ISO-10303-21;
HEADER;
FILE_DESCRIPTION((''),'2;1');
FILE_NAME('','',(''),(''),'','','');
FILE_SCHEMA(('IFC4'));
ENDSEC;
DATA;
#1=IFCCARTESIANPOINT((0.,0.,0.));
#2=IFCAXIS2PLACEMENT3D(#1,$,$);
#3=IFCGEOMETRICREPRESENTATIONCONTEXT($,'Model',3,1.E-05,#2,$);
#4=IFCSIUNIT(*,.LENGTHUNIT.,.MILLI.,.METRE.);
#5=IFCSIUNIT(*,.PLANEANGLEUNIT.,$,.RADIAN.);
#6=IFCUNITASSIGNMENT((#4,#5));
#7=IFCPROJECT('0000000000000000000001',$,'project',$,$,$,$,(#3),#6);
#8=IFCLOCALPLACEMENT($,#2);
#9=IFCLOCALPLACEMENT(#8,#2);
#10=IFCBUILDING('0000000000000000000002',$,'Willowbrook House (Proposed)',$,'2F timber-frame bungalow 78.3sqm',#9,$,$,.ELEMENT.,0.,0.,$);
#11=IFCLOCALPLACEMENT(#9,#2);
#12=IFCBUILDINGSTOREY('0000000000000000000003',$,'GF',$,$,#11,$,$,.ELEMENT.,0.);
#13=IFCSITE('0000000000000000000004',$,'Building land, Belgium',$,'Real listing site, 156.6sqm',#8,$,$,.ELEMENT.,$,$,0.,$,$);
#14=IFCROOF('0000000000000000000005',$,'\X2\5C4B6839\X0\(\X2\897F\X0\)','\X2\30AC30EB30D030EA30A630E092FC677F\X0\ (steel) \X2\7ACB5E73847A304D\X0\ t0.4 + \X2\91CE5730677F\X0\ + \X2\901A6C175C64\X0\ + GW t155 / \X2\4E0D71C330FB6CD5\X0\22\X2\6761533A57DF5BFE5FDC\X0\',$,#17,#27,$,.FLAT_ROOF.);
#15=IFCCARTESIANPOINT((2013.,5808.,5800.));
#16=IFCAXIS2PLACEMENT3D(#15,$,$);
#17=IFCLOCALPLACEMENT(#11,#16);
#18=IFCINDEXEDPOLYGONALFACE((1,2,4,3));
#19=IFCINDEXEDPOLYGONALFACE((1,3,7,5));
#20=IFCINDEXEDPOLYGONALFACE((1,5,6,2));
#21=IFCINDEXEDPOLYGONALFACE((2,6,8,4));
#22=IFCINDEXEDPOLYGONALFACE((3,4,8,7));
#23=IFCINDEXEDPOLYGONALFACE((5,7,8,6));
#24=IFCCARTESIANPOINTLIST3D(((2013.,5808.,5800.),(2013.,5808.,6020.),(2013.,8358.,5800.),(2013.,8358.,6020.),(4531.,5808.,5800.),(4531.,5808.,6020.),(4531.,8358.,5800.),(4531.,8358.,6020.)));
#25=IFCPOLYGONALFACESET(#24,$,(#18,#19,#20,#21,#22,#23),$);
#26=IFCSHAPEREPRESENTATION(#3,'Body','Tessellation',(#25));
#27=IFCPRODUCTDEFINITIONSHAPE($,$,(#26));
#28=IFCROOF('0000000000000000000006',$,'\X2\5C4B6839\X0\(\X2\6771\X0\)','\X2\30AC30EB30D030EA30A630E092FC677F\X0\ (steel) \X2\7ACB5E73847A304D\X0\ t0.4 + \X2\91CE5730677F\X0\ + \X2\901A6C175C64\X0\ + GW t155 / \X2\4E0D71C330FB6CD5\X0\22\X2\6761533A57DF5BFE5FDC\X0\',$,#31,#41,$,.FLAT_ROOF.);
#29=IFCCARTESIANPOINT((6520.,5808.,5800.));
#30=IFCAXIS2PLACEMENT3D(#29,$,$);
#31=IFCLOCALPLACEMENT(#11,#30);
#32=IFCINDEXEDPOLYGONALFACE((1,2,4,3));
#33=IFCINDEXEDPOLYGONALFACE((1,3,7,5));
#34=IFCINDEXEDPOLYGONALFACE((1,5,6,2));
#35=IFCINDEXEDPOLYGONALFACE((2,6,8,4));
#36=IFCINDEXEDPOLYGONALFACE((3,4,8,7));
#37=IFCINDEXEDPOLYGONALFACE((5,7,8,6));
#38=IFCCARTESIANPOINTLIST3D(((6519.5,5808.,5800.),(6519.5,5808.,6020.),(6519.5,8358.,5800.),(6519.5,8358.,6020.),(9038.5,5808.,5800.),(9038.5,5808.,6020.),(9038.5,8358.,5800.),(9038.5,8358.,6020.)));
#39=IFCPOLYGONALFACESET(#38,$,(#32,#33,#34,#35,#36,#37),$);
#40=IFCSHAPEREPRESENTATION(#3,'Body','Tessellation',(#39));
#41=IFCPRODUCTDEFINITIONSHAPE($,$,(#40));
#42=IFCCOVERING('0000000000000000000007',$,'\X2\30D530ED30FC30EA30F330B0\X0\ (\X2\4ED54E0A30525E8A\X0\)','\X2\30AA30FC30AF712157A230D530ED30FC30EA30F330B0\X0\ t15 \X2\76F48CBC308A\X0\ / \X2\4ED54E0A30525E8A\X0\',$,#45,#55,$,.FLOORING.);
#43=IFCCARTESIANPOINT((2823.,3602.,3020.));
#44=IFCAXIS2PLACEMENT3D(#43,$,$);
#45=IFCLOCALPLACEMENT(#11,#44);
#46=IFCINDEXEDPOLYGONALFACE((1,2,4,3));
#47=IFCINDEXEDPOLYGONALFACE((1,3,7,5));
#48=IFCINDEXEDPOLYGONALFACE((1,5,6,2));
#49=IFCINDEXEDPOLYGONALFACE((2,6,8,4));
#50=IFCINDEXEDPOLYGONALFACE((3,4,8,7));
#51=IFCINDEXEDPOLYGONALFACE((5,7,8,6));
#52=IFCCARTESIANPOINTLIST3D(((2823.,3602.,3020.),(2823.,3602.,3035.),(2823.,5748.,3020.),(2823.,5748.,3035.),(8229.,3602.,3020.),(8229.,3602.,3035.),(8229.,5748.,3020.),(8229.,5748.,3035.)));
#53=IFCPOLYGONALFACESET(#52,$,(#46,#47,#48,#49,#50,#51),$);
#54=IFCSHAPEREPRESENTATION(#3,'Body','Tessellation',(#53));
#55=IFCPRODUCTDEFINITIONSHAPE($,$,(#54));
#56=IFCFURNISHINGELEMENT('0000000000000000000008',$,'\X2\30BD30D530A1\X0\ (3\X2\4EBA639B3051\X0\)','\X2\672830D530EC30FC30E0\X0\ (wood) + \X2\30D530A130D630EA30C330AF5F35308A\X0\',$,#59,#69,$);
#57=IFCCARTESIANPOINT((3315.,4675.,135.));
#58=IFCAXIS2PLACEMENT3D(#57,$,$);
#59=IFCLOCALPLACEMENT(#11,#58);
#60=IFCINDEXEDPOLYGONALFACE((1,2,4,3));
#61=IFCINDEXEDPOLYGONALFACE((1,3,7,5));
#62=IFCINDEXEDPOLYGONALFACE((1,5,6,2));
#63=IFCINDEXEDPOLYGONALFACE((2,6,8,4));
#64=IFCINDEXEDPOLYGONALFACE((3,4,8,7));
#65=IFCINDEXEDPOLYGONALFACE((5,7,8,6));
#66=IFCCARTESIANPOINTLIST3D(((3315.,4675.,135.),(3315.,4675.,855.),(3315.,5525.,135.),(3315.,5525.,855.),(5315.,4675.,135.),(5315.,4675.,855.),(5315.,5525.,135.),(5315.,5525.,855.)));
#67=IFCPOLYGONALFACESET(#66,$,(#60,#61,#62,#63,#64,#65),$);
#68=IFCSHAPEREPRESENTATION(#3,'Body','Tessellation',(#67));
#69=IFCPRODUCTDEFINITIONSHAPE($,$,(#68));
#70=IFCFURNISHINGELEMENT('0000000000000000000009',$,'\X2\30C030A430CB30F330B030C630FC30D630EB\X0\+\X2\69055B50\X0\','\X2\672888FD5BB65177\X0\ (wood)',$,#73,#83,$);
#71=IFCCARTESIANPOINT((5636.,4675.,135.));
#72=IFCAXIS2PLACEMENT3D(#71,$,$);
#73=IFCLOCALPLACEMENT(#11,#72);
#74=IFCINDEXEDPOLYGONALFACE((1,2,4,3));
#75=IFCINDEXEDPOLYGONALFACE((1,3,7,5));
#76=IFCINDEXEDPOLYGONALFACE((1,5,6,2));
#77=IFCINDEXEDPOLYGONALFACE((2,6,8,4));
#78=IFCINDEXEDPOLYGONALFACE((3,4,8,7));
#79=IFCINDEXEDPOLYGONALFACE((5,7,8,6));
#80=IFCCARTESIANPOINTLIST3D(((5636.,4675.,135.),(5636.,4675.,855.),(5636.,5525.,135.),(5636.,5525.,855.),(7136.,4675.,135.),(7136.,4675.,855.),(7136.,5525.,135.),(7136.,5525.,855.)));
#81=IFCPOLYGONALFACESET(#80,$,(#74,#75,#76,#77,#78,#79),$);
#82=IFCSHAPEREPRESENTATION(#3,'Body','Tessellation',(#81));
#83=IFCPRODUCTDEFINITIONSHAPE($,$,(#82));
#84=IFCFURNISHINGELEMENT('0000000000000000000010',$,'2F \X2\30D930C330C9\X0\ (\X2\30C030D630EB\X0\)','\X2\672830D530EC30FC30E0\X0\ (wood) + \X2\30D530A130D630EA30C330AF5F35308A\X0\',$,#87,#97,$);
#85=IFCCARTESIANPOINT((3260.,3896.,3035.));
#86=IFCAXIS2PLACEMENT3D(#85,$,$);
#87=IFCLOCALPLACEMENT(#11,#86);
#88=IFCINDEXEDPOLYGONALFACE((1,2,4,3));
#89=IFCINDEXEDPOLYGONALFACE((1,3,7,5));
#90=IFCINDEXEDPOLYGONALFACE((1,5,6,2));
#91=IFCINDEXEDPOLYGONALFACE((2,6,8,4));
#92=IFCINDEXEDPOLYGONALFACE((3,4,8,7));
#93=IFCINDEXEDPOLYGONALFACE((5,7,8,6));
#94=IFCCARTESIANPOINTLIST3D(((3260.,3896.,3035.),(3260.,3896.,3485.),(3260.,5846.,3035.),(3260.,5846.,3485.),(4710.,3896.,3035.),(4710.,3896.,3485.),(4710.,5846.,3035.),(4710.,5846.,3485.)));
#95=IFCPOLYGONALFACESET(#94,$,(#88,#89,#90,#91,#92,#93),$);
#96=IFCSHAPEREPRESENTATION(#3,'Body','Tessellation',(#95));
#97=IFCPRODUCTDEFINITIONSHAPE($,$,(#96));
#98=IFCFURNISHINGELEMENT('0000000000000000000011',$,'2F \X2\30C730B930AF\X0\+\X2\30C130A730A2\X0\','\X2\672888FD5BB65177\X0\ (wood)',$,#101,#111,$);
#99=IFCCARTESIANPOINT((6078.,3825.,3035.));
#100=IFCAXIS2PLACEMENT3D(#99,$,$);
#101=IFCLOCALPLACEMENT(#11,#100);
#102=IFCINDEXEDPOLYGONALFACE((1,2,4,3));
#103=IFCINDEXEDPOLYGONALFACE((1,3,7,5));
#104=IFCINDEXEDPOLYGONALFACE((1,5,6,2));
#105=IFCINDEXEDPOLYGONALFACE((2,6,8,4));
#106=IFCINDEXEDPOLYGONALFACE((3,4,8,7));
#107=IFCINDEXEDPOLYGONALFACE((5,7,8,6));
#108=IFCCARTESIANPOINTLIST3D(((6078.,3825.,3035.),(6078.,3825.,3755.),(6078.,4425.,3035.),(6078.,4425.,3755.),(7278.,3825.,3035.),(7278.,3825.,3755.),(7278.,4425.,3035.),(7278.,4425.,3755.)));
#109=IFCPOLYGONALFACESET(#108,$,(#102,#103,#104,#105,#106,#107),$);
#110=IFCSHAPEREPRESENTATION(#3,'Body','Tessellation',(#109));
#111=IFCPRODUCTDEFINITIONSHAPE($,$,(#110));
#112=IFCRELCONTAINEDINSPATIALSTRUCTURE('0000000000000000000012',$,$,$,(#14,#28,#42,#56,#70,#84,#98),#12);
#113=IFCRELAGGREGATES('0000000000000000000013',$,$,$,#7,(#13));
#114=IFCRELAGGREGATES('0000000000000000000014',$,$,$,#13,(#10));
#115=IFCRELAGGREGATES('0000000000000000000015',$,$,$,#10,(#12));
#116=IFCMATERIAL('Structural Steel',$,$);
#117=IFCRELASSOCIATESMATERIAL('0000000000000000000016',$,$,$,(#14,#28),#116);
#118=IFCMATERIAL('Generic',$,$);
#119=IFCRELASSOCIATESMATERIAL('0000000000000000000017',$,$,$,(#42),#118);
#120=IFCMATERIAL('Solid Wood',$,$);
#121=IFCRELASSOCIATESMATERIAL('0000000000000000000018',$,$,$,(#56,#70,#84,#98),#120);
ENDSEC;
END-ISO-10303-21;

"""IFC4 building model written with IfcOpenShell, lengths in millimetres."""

from ifc_helpers import new_model, si_unit, frame, frame_2d, origin, place, context, project, spatial, rectangle, extrude, material, element, save


model = new_model("IFC4")

# Units and contexts
model_context = context("Model", 3, precision=1e-05, world=origin())
ifc_project = project(units=[si_unit("LENGTHUNIT", "METRE", prefix="MILLI"), si_unit("PLANEANGLEUNIT", "RADIAN")], contexts=[model_context])

# Site, building, storey
site_placement = place(None, origin())
site = spatial("IfcSite", under=ifc_project, at=site_placement, Name="Building land, Belgium", ObjectType="Real listing site, 156.6sqm", CompositionType="ELEMENT", RefElevation=0.0)
building_placement = place(site_placement, origin())
building = spatial("IfcBuilding", under=site, at=building_placement, Name="Willowbrook House (Proposed)", ObjectType="2F timber-frame bungalow 78.3sqm", CompositionType="ELEMENT", ElevationOfRefHeight=0.0, ElevationOfTerrain=0.0)
storey_placement = place(building_placement, origin())
storey = spatial("IfcBuildingStorey", under=building, at=storey_placement, Name="GF", CompositionType="ELEMENT", Elevation=0.0)

# Shared definitions
ifc_material_1 = material(Name="Solid Wood")

# Roofs
ifc_material_2 = material(Name="Structural Steel")
roof_1_placement = place(storey_placement, frame((2013.0, 5808.0, 5800.0)))
element("IfcRoof", 1, at=roof_1_placement, inside=storey, material=ifc_material_2, Name="屋根(西)", Description="ガルバリウム鋼板 (steel) 立平葺き t0.4 + 野地板 + 通気層 + GW t155 / 不燃・法22条区域対応", PredefinedType="FLAT_ROOF", context=model_context, shape_type="SweptSolid", body=[
    extrude(rectangle(XDim=2518.0, YDim=2550.0, at=frame_2d((1259.0, 1275.0))), frame((2013.0, 5808.0, 5800.0)), (0.0, 0.0, 1.0), 220.0),
])
roof_2_placement = place(storey_placement, frame((6520.0, 5808.0, 5800.0)))
element("IfcRoof", 2, at=roof_2_placement, inside=storey, material=ifc_material_2, Name="屋根(東)", Description="ガルバリウム鋼板 (steel) 立平葺き t0.4 + 野地板 + 通気層 + GW t155 / 不燃・法22条区域対応", PredefinedType="FLAT_ROOF", context=model_context, shape_type="SweptSolid", body=[
    extrude(rectangle(XDim=2519.0, YDim=2550.0, at=frame_2d((1259.0, 1275.0))), frame((6520.0, 5808.0, 5800.0)), (0.0, 0.0, 1.0), 220.0),
])

# Covering
ifc_material_3 = material(Name="Generic")
covering_placement = place(storey_placement, frame((2823.0, 3602.0, 3020.0)))
element("IfcCovering", 3, at=covering_placement, inside=storey, material=ifc_material_3, Name="フローリング (仕上げ床)", Description="オーク無垢フローリング t15 直貼り / 仕上げ床", PredefinedType="FLOORING", context=model_context, shape_type="SweptSolid", body=[
    extrude(rectangle(XDim=5406.0, YDim=2146.0, at=frame_2d((2703.0, 1073.0))), frame((2823.0, 3602.0, 3020.0)), (0.0, 0.0, 1.0), 15.0),
])

# Furnishing elements
furnishing_1_placement = place(storey_placement, frame((3315.0, 4675.0, 135.0)))
element("IfcFurnishingElement", 4, at=furnishing_1_placement, inside=storey, material=ifc_material_1, Name="ソファ (3人掛け)", Description="木フレーム (wood) + ファブリック張り", context=model_context, shape_type="SweptSolid", body=[
    extrude(rectangle(XDim=2000.0, YDim=850.0, at=frame_2d((1000.0, 425.0))), frame((3315.0, 4675.0, 135.0)), (0.0, 0.0, 1.0), 720.0),
])
furnishing_2_placement = place(storey_placement, frame((5636.0, 4675.0, 135.0)))
element("IfcFurnishingElement", 5, at=furnishing_2_placement, inside=storey, material=ifc_material_1, Name="ダイニングテーブル+椅子", Description="木製家具 (wood)", context=model_context, shape_type="SweptSolid", body=[
    extrude(rectangle(XDim=1500.0, YDim=850.0, at=frame_2d((750.0, 425.0))), frame((5636.0, 4675.0, 135.0)), (0.0, 0.0, 1.0), 720.0),
])
furnishing_3_placement = place(storey_placement, frame((3260.0, 3896.0, 3035.0)))
element("IfcFurnishingElement", 6, at=furnishing_3_placement, inside=storey, material=ifc_material_1, Name="2F ベッド (ダブル)", Description="木フレーム (wood) + ファブリック張り", context=model_context, shape_type="SweptSolid", body=[
    extrude(rectangle(XDim=1450.0, YDim=1950.0, at=frame_2d((725.0, 975.0))), frame((3260.0, 3896.0, 3035.0)), (0.0, 0.0, 1.0), 450.0),
])
furnishing_4_placement = place(storey_placement, frame((6078.0, 3825.0, 3035.0)))
element("IfcFurnishingElement", 7, at=furnishing_4_placement, inside=storey, material=ifc_material_1, Name="2F デスク+チェア", Description="木製家具 (wood)", context=model_context, shape_type="SweptSolid", body=[
    extrude(rectangle(XDim=1200.0, YDim=600.0, at=frame_2d((600.0, 300.0))), frame((6078.0, 3825.0, 3035.0)), (0.0, 0.0, 1.0), 720.0),
])

save(model, "model.ifc")
